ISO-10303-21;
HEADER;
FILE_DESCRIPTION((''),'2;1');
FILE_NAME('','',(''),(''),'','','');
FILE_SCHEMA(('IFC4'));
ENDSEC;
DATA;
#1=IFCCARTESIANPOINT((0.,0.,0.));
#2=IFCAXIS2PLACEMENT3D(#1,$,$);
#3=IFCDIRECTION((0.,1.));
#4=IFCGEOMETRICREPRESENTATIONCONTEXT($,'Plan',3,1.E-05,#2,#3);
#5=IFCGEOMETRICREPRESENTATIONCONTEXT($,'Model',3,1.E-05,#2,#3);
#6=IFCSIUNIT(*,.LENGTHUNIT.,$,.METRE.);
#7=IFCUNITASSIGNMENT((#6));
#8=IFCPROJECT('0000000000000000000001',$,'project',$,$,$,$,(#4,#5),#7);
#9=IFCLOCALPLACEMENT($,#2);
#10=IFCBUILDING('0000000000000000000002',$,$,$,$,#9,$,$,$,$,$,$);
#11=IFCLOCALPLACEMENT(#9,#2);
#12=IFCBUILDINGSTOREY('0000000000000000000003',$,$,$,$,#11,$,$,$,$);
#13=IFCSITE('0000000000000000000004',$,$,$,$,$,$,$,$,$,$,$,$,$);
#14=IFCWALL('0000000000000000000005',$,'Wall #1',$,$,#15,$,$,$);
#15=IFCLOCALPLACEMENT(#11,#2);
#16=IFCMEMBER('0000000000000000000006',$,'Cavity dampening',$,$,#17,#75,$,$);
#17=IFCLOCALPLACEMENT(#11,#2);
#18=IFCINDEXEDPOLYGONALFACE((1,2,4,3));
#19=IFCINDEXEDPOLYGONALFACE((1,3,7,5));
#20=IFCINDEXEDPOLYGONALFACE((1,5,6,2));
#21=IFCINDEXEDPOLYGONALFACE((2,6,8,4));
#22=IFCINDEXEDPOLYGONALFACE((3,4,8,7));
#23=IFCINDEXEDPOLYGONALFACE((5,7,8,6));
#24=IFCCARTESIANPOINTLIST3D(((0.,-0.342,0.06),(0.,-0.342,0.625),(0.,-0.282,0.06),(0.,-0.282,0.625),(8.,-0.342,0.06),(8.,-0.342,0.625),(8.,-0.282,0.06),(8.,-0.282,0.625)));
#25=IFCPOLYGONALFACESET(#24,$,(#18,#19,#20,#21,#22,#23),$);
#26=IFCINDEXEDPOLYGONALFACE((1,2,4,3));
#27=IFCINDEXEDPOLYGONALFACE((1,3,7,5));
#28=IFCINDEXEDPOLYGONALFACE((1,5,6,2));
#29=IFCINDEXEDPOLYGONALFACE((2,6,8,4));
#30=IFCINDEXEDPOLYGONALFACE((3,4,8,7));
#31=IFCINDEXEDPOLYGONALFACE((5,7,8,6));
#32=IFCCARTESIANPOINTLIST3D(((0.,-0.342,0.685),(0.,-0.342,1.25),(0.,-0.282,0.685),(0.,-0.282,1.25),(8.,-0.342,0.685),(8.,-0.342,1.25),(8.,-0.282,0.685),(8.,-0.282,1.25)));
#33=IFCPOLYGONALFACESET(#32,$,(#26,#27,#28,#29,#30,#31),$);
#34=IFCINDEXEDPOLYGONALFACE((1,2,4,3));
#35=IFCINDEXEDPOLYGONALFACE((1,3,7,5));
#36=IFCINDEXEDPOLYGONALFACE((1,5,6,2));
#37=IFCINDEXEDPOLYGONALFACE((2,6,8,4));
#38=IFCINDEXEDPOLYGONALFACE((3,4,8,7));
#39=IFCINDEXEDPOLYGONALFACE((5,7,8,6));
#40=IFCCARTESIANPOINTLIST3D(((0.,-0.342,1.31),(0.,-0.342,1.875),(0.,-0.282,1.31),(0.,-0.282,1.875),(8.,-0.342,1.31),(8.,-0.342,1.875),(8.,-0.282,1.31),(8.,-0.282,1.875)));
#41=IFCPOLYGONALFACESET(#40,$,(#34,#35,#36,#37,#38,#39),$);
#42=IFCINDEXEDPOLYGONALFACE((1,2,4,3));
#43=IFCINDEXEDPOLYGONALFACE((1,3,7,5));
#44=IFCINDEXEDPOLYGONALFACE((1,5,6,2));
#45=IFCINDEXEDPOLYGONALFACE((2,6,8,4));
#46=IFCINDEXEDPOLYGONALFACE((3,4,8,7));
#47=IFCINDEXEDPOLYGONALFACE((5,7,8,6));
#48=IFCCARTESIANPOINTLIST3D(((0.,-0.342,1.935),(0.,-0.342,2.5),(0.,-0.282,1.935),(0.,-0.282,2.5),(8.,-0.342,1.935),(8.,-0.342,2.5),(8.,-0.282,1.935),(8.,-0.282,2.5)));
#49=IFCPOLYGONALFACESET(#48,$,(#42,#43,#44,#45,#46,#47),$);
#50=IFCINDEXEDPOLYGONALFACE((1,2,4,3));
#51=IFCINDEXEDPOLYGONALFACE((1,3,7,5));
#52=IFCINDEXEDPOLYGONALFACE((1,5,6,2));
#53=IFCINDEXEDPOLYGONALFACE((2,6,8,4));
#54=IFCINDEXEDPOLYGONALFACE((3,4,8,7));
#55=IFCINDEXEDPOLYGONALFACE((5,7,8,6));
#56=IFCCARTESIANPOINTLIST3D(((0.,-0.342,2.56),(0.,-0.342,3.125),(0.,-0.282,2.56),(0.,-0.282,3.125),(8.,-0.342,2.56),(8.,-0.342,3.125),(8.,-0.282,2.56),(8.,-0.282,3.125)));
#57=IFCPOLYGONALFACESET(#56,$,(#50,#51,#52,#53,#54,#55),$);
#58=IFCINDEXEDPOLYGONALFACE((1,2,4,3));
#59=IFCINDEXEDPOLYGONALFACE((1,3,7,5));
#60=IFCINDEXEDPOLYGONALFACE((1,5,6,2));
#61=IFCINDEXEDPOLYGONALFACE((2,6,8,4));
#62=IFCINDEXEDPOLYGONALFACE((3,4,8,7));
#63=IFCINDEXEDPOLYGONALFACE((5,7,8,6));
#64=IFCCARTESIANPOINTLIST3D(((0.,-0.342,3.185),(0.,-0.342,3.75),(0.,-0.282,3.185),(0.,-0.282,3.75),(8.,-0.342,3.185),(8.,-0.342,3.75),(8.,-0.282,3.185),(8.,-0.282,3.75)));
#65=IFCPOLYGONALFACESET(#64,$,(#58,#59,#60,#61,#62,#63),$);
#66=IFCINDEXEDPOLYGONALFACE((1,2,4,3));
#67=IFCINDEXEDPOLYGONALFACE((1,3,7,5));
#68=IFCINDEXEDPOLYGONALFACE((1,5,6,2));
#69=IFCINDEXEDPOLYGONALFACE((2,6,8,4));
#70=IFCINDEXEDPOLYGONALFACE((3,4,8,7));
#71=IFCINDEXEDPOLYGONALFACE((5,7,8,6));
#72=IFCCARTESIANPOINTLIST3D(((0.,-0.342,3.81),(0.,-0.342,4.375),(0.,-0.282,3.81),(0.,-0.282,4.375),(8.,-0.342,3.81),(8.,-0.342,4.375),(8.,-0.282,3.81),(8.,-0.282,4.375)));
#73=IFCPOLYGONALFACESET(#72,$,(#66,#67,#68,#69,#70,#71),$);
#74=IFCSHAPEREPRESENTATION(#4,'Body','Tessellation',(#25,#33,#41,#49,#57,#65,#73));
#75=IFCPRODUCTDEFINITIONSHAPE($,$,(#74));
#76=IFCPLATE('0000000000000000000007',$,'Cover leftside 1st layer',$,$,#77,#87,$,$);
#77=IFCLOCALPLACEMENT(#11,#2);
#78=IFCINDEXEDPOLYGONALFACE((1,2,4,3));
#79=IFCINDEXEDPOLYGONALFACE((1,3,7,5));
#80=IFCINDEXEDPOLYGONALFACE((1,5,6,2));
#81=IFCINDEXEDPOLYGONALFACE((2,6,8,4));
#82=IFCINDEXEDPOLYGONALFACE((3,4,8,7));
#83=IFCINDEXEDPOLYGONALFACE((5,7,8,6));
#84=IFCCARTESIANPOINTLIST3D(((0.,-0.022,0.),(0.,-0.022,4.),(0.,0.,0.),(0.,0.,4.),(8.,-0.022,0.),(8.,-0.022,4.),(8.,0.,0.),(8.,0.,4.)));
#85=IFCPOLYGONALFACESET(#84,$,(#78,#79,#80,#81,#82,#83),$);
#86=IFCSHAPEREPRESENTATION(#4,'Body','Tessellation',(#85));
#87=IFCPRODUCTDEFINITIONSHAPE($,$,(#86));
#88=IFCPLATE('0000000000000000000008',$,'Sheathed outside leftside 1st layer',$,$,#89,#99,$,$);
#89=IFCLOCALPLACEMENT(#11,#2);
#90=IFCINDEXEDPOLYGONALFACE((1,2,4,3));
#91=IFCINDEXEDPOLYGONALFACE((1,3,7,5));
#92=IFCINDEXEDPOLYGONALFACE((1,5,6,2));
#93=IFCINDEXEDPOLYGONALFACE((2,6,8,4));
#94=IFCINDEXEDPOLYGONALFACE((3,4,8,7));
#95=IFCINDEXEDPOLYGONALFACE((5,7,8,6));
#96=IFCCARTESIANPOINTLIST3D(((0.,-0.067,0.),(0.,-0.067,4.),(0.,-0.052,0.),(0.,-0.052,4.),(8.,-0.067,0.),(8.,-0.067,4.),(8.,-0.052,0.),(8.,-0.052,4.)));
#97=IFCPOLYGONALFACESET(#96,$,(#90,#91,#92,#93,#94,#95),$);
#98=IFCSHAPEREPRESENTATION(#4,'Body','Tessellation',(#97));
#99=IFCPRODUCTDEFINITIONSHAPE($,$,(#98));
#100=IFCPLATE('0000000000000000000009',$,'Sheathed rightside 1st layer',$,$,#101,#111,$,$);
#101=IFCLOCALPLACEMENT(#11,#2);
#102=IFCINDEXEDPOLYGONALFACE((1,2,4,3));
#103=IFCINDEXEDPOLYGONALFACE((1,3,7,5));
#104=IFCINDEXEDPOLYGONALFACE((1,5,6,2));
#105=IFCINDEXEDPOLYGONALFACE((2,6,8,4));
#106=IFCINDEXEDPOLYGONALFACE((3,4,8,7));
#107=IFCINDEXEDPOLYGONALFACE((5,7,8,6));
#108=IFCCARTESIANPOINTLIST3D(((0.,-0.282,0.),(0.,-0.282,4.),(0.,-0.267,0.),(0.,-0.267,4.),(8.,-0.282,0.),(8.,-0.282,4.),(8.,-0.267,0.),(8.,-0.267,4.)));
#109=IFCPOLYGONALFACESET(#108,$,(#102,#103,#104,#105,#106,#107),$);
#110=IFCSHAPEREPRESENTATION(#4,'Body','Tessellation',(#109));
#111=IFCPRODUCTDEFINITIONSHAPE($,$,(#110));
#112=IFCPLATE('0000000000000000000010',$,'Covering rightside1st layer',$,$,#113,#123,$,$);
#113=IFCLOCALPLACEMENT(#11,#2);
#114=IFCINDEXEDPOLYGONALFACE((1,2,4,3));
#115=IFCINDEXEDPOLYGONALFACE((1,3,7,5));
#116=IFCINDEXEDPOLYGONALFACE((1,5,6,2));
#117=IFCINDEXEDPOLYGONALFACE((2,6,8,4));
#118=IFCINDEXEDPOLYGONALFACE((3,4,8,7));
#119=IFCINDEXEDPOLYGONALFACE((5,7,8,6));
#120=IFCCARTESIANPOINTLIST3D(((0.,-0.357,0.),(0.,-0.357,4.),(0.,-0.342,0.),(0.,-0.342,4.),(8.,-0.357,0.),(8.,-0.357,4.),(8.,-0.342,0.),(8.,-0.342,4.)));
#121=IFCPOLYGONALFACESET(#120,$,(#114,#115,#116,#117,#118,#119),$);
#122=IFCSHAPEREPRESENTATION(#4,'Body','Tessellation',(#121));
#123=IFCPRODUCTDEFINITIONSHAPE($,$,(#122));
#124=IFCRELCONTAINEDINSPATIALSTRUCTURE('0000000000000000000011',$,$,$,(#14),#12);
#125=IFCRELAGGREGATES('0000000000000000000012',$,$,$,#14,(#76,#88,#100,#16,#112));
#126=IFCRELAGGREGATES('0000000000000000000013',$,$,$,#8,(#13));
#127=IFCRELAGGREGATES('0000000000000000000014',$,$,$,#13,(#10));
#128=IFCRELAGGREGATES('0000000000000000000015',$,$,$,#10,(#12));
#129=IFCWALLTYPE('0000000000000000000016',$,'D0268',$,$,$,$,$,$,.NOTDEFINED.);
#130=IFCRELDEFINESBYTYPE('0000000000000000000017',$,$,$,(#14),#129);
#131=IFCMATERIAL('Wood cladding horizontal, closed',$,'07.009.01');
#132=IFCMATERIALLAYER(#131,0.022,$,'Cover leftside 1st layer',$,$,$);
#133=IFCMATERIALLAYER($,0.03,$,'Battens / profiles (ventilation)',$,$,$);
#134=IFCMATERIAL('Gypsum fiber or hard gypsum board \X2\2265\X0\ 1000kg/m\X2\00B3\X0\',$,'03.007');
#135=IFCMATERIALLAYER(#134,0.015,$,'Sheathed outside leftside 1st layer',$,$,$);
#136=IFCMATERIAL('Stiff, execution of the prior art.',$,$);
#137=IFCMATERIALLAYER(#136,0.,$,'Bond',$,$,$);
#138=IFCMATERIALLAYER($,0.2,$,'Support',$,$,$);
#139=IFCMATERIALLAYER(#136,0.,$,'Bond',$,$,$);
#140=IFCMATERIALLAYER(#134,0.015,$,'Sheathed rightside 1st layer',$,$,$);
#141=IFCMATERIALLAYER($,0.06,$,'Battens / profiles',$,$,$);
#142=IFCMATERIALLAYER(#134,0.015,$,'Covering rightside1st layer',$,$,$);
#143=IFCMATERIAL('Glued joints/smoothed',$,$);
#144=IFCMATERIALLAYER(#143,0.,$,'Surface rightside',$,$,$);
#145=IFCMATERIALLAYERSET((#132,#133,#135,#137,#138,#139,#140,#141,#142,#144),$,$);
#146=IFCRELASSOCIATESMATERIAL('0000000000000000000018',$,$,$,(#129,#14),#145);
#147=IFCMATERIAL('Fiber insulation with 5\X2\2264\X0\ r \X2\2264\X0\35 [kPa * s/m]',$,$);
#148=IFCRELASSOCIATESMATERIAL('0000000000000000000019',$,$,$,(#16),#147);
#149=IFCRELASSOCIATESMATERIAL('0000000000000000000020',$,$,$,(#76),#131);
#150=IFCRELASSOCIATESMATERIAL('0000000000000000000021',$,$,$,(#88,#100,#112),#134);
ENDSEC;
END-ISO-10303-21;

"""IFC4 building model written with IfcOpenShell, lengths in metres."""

from ifc_helpers import new_model, si_unit, direction, frame, frame_2d, origin, origin_with_axes, place, context, project, spatial, rectangle, extrude, material, layer, layer_set, type_object, element, aggregate, save


model = new_model("IFC4")

# Units and contexts
plan_context = context("Plan", 3, precision=1e-05, world=origin(), true_north=direction((0.0, 1.0)))
model_context = context("Model", 3, precision=1e-05, world=origin(), true_north=direction((0.0, 1.0)))
ifc_project = project(units=[si_unit("LENGTHUNIT", "METRE")], contexts=[plan_context, model_context])

# Site, building, storey
site = spatial("IfcSite", under=ifc_project)
building_placement = place(None, origin())
building = spatial("IfcBuilding", under=site, at=building_placement)
storey_placement = place(building_placement, origin())
storey = spatial("IfcBuildingStorey", under=building, at=storey_placement)

# Wall, member, plates
ifc_material_1 = material(Name="Wood cladding horizontal, closed", Category="07.009.01")
ifc_layer_1 = layer(ifc_material_1, 0.022, Name="Cover leftside 1st layer")
ifc_layer_2 = layer(None, 0.03, Name="Battens / profiles (ventilation)")
ifc_material_2 = material(Name="Gypsum fiber or hard gypsum board ≥ 1000kg/m³", Category="03.007")
ifc_layer_3 = layer(ifc_material_2, 0.015, Name="Sheathed outside leftside 1st layer")
ifc_material_3 = material(Name="Stiff, execution of the prior art.")
ifc_layer_4 = layer(ifc_material_3, 0.0, Name="Bond")
ifc_layer_5 = layer(None, 0.2, Name="Support")
ifc_layer_6 = layer(ifc_material_3, 0.0, Name="Bond")
ifc_layer_7 = layer(ifc_material_2, 0.015, Name="Sheathed rightside 1st layer")
ifc_layer_8 = layer(None, 0.06, Name="Battens / profiles")
ifc_layer_9 = layer(ifc_material_2, 0.015, Name="Covering rightside1st layer")
ifc_material_4 = material(Name="Glued joints/smoothed")
ifc_layer_10 = layer(ifc_material_4, 0.0, Name="Surface rightside")
ifc_layer_set = layer_set([ifc_layer_1, ifc_layer_2, ifc_layer_3, ifc_layer_4, ifc_layer_5, ifc_layer_6, ifc_layer_7, ifc_layer_8, ifc_layer_9, ifc_layer_10])
wall_type = type_object("IfcWallType", Name="D0268", PredefinedType="NOTDEFINED", material=ifc_layer_set)
wall_placement = place(None, frame((0.0, 0.0, 0.0), z_axis=(0.0, -1.0, 0.0), x_axis=(1.0, 0.0, 0.0)))
wall = element("IfcWall", 1, at=wall_placement, inside=storey, type_object=wall_type, material=ifc_layer_set, Name="Wall #1")
ifc_material_5 = material(Name="Fiber insulation with 5≤ r ≤35 [kPa * s/m]")
member_1_placement = place(wall_placement, origin())
member_1 = element("IfcMember", 2, at=member_1_placement, material=ifc_material_5, Name="Cavity dampening", context=plan_context, shape_type="SweptSolid", body=[
    extrude(rectangle(XDim=0.565, YDim=0.06, at=frame_2d((0.2825, 0.03), x_axis=(1.0, 0.0))), frame((0.0, 0.06, 0.282), z_axis=(1.0, 0.0, 0.0), x_axis=(0.0, 1.0, 0.0)), (0.0, 0.0, 1.0), 8.0),
    extrude(rectangle(XDim=0.565, YDim=0.06, at=frame_2d((0.2825, 0.03), x_axis=(1.0, 0.0))), frame((0.0, 0.685, 0.282), z_axis=(1.0, 0.0, 0.0), x_axis=(0.0, 1.0, 0.0)), (0.0, 0.0, 1.0), 8.0),
    extrude(rectangle(XDim=0.565, YDim=0.06, at=frame_2d((0.2825, 0.03), x_axis=(1.0, 0.0))), frame((0.0, 1.31, 0.282), z_axis=(1.0, 0.0, 0.0), x_axis=(0.0, 1.0, 0.0)), (0.0, 0.0, 1.0), 8.0),
    extrude(rectangle(XDim=0.565, YDim=0.06, at=frame_2d((0.2825, 0.03), x_axis=(1.0, 0.0))), frame((0.0, 1.935, 0.282), z_axis=(1.0, 0.0, 0.0), x_axis=(0.0, 1.0, 0.0)), (0.0, 0.0, 1.0), 8.0),
    extrude(rectangle(XDim=0.565, YDim=0.06, at=frame_2d((0.2825, 0.03), x_axis=(1.0, 0.0))), frame((0.0, 2.56, 0.282), z_axis=(1.0, 0.0, 0.0), x_axis=(0.0, 1.0, 0.0)), (0.0, 0.0, 1.0), 8.0),
    extrude(rectangle(XDim=0.565, YDim=0.06, at=frame_2d((0.2825, 0.03), x_axis=(1.0, 0.0))), frame((0.0, 3.185, 0.282), z_axis=(1.0, 0.0, 0.0), x_axis=(0.0, 1.0, 0.0)), (0.0, 0.0, 1.0), 8.0),
    extrude(rectangle(XDim=0.565, YDim=0.06, at=frame_2d((0.2825, 0.03), x_axis=(1.0, 0.0))), frame((0.0, 3.81, 0.282), z_axis=(1.0, 0.0, 0.0), x_axis=(0.0, 1.0, 0.0)), (0.0, 0.0, 1.0), 8.0),
])
plate_1_placement = place(wall_placement, origin())
plate_1 = element("IfcPlate", 3, at=plate_1_placement, material=ifc_material_1, Name="Cover leftside 1st layer", context=plan_context, shape_type="SweptSolid", body=[
    extrude(rectangle(XDim=8.0, YDim=4.0, at=frame_2d((4.0, 2.0), x_axis=(1.0, 0.0))), origin_with_axes(), (0.0, 0.0, 1.0), 0.022),
])
plate_2_placement = place(wall_placement, origin())
plate_2 = element("IfcPlate", 4, at=plate_2_placement, material=ifc_material_2, Name="Sheathed outside leftside 1st layer", context=plan_context, shape_type="SweptSolid", body=[
    extrude(rectangle(XDim=8.0, YDim=4.0, at=frame_2d((4.0, 2.0), x_axis=(1.0, 0.0))), frame((0.0, 0.0, 0.052), z_axis=(0.0, 0.0, 1.0), x_axis=(1.0, 0.0, 0.0)), (0.0, 0.0, 1.0), 0.015),
])
plate_3_placement = place(wall_placement, origin())
plate_3 = element("IfcPlate", 5, at=plate_3_placement, material=ifc_material_2, Name="Sheathed rightside 1st layer", context=plan_context, shape_type="SweptSolid", body=[
    extrude(rectangle(XDim=8.0, YDim=4.0, at=frame_2d((4.0, 2.0), x_axis=(1.0, 0.0))), frame((0.0, 0.0, 0.267), z_axis=(0.0, 0.0, 1.0), x_axis=(1.0, 0.0, 0.0)), (0.0, 0.0, 1.0), 0.015),
])
plate_4_placement = place(wall_placement, origin())
plate_4 = element("IfcPlate", 6, at=plate_4_placement, material=ifc_material_2, Name="Covering rightside1st layer", context=plan_context, shape_type="SweptSolid", body=[
    extrude(rectangle(XDim=8.0, YDim=4.0, at=frame_2d((4.0, 2.0), x_axis=(1.0, 0.0))), frame((0.0, 0.0, 0.342), z_axis=(0.0, 0.0, 1.0), x_axis=(1.0, 0.0, 0.0)), (0.0, 0.0, 1.0), 0.015),
])
aggregate(wall, [plate_1, plate_2, plate_3, member_1, plate_4])

save(model, "model.ifc")
